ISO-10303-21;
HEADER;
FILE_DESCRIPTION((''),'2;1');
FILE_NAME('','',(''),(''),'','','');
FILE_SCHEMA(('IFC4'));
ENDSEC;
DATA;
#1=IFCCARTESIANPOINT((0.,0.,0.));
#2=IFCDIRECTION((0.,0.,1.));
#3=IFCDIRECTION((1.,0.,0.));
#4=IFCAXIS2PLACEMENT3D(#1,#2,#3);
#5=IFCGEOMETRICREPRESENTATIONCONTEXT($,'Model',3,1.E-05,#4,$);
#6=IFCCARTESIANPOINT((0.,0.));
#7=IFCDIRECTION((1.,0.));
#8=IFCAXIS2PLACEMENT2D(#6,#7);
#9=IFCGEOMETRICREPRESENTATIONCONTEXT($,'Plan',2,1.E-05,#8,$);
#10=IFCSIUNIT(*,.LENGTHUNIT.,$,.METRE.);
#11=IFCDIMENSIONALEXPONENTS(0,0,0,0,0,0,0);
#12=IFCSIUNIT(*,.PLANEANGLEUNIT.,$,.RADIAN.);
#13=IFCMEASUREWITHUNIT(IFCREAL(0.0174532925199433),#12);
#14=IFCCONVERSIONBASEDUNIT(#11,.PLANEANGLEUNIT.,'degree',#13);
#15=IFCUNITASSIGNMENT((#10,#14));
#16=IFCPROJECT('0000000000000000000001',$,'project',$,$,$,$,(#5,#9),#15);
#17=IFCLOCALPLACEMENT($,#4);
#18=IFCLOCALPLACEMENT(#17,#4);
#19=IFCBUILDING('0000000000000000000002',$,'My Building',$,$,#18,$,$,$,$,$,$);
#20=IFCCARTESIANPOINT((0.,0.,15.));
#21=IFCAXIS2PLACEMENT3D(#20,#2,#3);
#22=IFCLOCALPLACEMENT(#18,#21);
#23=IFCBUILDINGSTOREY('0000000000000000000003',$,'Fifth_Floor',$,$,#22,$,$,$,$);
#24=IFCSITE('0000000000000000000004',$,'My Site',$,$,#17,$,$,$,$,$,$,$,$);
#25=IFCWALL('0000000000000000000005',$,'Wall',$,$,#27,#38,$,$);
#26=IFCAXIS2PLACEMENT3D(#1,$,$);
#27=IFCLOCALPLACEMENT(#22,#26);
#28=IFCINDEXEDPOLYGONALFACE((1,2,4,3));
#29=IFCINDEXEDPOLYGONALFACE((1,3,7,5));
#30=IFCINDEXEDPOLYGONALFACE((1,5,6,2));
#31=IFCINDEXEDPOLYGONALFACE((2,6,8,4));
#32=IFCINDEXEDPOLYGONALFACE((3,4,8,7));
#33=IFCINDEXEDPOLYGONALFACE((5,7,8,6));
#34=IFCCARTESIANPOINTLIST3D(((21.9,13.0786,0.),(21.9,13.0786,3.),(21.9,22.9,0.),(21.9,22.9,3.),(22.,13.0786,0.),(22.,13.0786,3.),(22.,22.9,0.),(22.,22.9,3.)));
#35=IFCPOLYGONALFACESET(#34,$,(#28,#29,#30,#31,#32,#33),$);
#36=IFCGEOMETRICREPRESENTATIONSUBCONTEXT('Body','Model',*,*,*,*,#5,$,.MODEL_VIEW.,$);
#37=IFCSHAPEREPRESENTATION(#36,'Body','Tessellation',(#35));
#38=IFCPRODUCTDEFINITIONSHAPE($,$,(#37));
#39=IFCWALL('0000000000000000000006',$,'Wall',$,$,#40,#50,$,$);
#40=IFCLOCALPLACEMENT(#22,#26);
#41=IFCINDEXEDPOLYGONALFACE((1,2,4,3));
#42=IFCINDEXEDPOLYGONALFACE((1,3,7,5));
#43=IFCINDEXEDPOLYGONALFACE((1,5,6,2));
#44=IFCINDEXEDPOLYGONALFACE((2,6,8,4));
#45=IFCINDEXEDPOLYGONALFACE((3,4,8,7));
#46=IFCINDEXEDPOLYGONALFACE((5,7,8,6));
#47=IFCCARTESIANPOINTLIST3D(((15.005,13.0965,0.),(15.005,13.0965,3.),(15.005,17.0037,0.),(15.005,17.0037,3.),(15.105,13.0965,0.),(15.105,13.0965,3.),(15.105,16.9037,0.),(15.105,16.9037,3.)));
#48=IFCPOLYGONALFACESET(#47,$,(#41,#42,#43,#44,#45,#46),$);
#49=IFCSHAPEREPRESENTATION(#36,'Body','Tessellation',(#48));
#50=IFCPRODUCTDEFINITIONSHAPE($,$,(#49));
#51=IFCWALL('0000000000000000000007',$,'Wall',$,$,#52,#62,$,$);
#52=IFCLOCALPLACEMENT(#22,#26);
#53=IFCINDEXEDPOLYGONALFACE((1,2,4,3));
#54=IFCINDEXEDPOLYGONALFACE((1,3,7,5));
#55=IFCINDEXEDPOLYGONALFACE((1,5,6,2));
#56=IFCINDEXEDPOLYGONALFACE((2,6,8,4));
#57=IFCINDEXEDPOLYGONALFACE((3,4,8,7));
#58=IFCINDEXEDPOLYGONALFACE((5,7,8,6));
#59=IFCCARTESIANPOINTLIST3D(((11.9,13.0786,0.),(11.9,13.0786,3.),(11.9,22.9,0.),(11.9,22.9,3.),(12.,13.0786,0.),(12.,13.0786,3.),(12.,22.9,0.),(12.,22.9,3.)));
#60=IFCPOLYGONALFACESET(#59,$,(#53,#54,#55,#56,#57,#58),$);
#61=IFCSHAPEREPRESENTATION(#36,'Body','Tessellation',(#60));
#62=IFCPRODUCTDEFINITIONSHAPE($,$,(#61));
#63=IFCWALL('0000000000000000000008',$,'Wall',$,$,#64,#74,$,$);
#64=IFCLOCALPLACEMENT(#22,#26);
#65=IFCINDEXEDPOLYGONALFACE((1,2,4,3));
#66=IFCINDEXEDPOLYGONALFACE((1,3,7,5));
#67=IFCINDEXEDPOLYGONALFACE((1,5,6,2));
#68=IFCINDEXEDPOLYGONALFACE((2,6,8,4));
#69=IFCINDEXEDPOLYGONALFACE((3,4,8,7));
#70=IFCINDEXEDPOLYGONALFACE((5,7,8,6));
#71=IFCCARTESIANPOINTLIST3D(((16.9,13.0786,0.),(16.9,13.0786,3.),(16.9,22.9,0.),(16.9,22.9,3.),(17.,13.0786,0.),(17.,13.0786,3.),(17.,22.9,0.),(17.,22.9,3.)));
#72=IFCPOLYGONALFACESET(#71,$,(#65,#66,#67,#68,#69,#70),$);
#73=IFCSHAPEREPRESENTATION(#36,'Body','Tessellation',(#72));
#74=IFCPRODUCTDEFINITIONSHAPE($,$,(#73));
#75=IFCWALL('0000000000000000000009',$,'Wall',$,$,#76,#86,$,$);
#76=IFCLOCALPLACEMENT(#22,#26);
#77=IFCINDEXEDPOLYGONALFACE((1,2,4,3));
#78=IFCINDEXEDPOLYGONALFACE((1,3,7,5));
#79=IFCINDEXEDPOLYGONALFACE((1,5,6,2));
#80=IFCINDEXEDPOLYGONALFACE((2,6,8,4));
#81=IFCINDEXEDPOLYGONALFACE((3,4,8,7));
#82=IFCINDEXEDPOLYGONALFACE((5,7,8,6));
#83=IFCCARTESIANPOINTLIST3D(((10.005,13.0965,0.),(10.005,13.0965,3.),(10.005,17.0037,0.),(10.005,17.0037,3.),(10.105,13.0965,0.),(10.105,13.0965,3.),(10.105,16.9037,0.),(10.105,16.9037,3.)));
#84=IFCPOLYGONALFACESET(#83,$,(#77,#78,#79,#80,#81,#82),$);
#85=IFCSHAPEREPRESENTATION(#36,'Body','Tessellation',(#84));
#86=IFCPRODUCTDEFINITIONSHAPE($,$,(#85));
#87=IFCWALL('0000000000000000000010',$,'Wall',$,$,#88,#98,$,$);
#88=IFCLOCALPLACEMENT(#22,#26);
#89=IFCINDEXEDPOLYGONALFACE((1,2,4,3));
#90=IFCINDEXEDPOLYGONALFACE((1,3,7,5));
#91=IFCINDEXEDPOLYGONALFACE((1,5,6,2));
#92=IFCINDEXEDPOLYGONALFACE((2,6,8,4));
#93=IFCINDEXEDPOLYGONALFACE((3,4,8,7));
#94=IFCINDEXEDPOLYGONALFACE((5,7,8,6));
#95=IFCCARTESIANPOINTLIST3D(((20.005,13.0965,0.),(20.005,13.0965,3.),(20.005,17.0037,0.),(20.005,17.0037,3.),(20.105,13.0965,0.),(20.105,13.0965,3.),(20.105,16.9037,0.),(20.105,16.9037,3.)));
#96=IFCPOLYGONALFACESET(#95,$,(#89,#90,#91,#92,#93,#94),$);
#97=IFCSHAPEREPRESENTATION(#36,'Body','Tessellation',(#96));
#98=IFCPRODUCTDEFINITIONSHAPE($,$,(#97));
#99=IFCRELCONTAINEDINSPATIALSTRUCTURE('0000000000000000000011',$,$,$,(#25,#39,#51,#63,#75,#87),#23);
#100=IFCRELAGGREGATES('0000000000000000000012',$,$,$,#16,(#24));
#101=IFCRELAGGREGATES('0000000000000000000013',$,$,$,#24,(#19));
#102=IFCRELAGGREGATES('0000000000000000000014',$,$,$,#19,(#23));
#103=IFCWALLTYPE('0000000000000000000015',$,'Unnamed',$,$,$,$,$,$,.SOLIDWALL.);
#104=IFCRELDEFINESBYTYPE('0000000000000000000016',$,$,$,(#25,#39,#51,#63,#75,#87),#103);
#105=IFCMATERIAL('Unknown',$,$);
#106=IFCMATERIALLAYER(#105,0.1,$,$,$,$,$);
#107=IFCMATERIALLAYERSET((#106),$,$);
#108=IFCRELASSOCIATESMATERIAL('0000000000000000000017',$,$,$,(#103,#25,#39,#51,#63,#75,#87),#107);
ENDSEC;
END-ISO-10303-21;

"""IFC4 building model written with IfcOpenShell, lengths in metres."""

from ifc_helpers import new_model, entity, si_unit, converted_unit, frame, origin_with_axes, origin_2d_with_axis, place, context, subcontext, project, spatial, line, indexed_curve, outline, extrude, material, layer, layer_set, layer_usage, type_object, element, save


model = new_model("IFC4")

# Units and contexts
model_context = context("Model", 3, precision=1e-05, world=origin_with_axes())
plan_context = context("Plan", 2, precision=1e-05, world=origin_2d_with_axis())
body_context_1 = subcontext(model_context, "Body", "Model", "MODEL_VIEW")
ifc_project = project(units=[si_unit("LENGTHUNIT", "METRE"), converted_unit("PLANEANGLEUNIT", "degree", entity("IfcReal", 0.0174532925199433), si_unit("PLANEANGLEUNIT", "RADIAN"), dimensions=[0, 0, 0, 0, 0, 0, 0])], contexts=[model_context, plan_context])

# Site, building, storey
site_placement = place(None, origin_with_axes())
site = spatial("IfcSite", under=ifc_project, at=site_placement, Name="My Site")
building_placement = place(site_placement, origin_with_axes())
building = spatial("IfcBuilding", under=site, at=building_placement, Name="My Building")
storey_placement = place(building_placement, frame((0.0, 0.0, 15.0), z_axis=(0.0, 0.0, 1.0), x_axis=(1.0, 0.0, 0.0)))
storey = spatial("IfcBuildingStorey", under=building, at=storey_placement, Name="Fifth_Floor")

# Walls
ifc_material = material(Name="Unknown")
ifc_layer = layer(ifc_material, 0.1)
ifc_layer_set = layer_set([ifc_layer])
ifc_layer_usage_1 = layer_usage(ifc_layer_set, "AXIS2", "POSITIVE", 0.0)
wall_type = type_object("IfcWallType", Name="Unnamed", PredefinedType="SOLIDWALL", material=ifc_layer_set)
wall_1_placement = place(storey_placement, frame((21.9, 22.9, 0.0), z_axis=(0.0, 0.0, 1.0), x_axis=(0.0, -1.0, 0.0)))
element("IfcWall", 1, at=wall_1_placement, inside=storey, type_object=wall_type, material=ifc_layer_usage_1, Name="Wall", context=body_context_1, shape_type="SweptSolid", body=[
    extrude(outline(indexed_curve([(0.0, 0.0), (0.0, 0.1), (9.8214, 0.1), (9.8214, 0.0)], segments=[line(1, 2, 3, 4, 1)])), origin_with_axes(), (0.0, 0.0, 1.0), 3.0),
])
ifc_layer_usage_2 = layer_usage(ifc_layer_set, "AXIS2", "POSITIVE", 0.0)
wall_2_placement = place(storey_placement, frame((15.005, 17.0037, 0.0), z_axis=(0.0, 0.0, 1.0), x_axis=(0.0, -1.0, 0.0)))
element("IfcWall", 2, at=wall_2_placement, inside=storey, type_object=wall_type, material=ifc_layer_usage_2, Name="Wall", context=body_context_1, shape_type="SweptSolid", body=[
    extrude(outline(indexed_curve([(0.0, 0.0), (0.1, 0.1), (3.9072, 0.1), (3.9072, 0.0)], segments=[line(1, 2, 3, 4, 1)])), origin_with_axes(), (0.0, 0.0, 1.0), 3.0),
])
ifc_layer_usage_3 = layer_usage(ifc_layer_set, "AXIS2", "POSITIVE", 0.0)
wall_3_placement = place(storey_placement, frame((11.9, 22.9, 0.0), z_axis=(0.0, 0.0, 1.0), x_axis=(0.0, -1.0, 0.0)))
element("IfcWall", 3, at=wall_3_placement, inside=storey, type_object=wall_type, material=ifc_layer_usage_3, Name="Wall", context=body_context_1, shape_type="SweptSolid", body=[
    extrude(outline(indexed_curve([(0.0, 0.0), (0.0, 0.1), (9.8214, 0.1), (9.8214, 0.0)], segments=[line(1, 2, 3, 4, 1)])), origin_with_axes(), (0.0, 0.0, 1.0), 3.0),
])
ifc_layer_usage_4 = layer_usage(ifc_layer_set, "AXIS2", "POSITIVE", 0.0)
wall_4_placement = place(storey_placement, frame((16.9, 22.9, 0.0), z_axis=(0.0, 0.0, 1.0), x_axis=(0.0, -1.0, 0.0)))
element("IfcWall", 4, at=wall_4_placement, inside=storey, type_object=wall_type, material=ifc_layer_usage_4, Name="Wall", context=body_context_1, shape_type="SweptSolid", body=[
    extrude(outline(indexed_curve([(0.0, 0.0), (0.0, 0.1), (9.8214, 0.1), (9.8214, 0.0)], segments=[line(1, 2, 3, 4, 1)])), origin_with_axes(), (0.0, 0.0, 1.0), 3.0),
])
ifc_layer_usage_5 = layer_usage(ifc_layer_set, "AXIS2", "POSITIVE", 0.0)
wall_5_placement = place(storey_placement, frame((10.005, 17.0037, 0.0), z_axis=(0.0, 0.0, 1.0), x_axis=(0.0, -1.0, 0.0)))
element("IfcWall", 5, at=wall_5_placement, inside=storey, type_object=wall_type, material=ifc_layer_usage_5, Name="Wall", context=body_context_1, shape_type="SweptSolid", body=[
    extrude(outline(indexed_curve([(0.0, 0.0), (0.1, 0.1), (3.9072, 0.1), (3.9072, 0.0)], segments=[line(1, 2, 3, 4, 1)])), origin_with_axes(), (0.0, 0.0, 1.0), 3.0),
])
ifc_layer_usage_6 = layer_usage(ifc_layer_set, "AXIS2", "POSITIVE", 0.0)
wall_6_placement = place(storey_placement, frame((20.005, 17.0037, 0.0), z_axis=(0.0, 0.0, 1.0), x_axis=(0.0, -1.0, 0.0)))
element("IfcWall", 6, at=wall_6_placement, inside=storey, type_object=wall_type, material=ifc_layer_usage_6, Name="Wall", context=body_context_1, shape_type="SweptSolid", body=[
    extrude(outline(indexed_curve([(0.0, 0.0), (0.1, 0.1), (3.9072, 0.1), (3.9072, 0.0)], segments=[line(1, 2, 3, 4, 1)])), origin_with_axes(), (0.0, 0.0, 1.0), 3.0),
])

save(model, "model.ifc")
